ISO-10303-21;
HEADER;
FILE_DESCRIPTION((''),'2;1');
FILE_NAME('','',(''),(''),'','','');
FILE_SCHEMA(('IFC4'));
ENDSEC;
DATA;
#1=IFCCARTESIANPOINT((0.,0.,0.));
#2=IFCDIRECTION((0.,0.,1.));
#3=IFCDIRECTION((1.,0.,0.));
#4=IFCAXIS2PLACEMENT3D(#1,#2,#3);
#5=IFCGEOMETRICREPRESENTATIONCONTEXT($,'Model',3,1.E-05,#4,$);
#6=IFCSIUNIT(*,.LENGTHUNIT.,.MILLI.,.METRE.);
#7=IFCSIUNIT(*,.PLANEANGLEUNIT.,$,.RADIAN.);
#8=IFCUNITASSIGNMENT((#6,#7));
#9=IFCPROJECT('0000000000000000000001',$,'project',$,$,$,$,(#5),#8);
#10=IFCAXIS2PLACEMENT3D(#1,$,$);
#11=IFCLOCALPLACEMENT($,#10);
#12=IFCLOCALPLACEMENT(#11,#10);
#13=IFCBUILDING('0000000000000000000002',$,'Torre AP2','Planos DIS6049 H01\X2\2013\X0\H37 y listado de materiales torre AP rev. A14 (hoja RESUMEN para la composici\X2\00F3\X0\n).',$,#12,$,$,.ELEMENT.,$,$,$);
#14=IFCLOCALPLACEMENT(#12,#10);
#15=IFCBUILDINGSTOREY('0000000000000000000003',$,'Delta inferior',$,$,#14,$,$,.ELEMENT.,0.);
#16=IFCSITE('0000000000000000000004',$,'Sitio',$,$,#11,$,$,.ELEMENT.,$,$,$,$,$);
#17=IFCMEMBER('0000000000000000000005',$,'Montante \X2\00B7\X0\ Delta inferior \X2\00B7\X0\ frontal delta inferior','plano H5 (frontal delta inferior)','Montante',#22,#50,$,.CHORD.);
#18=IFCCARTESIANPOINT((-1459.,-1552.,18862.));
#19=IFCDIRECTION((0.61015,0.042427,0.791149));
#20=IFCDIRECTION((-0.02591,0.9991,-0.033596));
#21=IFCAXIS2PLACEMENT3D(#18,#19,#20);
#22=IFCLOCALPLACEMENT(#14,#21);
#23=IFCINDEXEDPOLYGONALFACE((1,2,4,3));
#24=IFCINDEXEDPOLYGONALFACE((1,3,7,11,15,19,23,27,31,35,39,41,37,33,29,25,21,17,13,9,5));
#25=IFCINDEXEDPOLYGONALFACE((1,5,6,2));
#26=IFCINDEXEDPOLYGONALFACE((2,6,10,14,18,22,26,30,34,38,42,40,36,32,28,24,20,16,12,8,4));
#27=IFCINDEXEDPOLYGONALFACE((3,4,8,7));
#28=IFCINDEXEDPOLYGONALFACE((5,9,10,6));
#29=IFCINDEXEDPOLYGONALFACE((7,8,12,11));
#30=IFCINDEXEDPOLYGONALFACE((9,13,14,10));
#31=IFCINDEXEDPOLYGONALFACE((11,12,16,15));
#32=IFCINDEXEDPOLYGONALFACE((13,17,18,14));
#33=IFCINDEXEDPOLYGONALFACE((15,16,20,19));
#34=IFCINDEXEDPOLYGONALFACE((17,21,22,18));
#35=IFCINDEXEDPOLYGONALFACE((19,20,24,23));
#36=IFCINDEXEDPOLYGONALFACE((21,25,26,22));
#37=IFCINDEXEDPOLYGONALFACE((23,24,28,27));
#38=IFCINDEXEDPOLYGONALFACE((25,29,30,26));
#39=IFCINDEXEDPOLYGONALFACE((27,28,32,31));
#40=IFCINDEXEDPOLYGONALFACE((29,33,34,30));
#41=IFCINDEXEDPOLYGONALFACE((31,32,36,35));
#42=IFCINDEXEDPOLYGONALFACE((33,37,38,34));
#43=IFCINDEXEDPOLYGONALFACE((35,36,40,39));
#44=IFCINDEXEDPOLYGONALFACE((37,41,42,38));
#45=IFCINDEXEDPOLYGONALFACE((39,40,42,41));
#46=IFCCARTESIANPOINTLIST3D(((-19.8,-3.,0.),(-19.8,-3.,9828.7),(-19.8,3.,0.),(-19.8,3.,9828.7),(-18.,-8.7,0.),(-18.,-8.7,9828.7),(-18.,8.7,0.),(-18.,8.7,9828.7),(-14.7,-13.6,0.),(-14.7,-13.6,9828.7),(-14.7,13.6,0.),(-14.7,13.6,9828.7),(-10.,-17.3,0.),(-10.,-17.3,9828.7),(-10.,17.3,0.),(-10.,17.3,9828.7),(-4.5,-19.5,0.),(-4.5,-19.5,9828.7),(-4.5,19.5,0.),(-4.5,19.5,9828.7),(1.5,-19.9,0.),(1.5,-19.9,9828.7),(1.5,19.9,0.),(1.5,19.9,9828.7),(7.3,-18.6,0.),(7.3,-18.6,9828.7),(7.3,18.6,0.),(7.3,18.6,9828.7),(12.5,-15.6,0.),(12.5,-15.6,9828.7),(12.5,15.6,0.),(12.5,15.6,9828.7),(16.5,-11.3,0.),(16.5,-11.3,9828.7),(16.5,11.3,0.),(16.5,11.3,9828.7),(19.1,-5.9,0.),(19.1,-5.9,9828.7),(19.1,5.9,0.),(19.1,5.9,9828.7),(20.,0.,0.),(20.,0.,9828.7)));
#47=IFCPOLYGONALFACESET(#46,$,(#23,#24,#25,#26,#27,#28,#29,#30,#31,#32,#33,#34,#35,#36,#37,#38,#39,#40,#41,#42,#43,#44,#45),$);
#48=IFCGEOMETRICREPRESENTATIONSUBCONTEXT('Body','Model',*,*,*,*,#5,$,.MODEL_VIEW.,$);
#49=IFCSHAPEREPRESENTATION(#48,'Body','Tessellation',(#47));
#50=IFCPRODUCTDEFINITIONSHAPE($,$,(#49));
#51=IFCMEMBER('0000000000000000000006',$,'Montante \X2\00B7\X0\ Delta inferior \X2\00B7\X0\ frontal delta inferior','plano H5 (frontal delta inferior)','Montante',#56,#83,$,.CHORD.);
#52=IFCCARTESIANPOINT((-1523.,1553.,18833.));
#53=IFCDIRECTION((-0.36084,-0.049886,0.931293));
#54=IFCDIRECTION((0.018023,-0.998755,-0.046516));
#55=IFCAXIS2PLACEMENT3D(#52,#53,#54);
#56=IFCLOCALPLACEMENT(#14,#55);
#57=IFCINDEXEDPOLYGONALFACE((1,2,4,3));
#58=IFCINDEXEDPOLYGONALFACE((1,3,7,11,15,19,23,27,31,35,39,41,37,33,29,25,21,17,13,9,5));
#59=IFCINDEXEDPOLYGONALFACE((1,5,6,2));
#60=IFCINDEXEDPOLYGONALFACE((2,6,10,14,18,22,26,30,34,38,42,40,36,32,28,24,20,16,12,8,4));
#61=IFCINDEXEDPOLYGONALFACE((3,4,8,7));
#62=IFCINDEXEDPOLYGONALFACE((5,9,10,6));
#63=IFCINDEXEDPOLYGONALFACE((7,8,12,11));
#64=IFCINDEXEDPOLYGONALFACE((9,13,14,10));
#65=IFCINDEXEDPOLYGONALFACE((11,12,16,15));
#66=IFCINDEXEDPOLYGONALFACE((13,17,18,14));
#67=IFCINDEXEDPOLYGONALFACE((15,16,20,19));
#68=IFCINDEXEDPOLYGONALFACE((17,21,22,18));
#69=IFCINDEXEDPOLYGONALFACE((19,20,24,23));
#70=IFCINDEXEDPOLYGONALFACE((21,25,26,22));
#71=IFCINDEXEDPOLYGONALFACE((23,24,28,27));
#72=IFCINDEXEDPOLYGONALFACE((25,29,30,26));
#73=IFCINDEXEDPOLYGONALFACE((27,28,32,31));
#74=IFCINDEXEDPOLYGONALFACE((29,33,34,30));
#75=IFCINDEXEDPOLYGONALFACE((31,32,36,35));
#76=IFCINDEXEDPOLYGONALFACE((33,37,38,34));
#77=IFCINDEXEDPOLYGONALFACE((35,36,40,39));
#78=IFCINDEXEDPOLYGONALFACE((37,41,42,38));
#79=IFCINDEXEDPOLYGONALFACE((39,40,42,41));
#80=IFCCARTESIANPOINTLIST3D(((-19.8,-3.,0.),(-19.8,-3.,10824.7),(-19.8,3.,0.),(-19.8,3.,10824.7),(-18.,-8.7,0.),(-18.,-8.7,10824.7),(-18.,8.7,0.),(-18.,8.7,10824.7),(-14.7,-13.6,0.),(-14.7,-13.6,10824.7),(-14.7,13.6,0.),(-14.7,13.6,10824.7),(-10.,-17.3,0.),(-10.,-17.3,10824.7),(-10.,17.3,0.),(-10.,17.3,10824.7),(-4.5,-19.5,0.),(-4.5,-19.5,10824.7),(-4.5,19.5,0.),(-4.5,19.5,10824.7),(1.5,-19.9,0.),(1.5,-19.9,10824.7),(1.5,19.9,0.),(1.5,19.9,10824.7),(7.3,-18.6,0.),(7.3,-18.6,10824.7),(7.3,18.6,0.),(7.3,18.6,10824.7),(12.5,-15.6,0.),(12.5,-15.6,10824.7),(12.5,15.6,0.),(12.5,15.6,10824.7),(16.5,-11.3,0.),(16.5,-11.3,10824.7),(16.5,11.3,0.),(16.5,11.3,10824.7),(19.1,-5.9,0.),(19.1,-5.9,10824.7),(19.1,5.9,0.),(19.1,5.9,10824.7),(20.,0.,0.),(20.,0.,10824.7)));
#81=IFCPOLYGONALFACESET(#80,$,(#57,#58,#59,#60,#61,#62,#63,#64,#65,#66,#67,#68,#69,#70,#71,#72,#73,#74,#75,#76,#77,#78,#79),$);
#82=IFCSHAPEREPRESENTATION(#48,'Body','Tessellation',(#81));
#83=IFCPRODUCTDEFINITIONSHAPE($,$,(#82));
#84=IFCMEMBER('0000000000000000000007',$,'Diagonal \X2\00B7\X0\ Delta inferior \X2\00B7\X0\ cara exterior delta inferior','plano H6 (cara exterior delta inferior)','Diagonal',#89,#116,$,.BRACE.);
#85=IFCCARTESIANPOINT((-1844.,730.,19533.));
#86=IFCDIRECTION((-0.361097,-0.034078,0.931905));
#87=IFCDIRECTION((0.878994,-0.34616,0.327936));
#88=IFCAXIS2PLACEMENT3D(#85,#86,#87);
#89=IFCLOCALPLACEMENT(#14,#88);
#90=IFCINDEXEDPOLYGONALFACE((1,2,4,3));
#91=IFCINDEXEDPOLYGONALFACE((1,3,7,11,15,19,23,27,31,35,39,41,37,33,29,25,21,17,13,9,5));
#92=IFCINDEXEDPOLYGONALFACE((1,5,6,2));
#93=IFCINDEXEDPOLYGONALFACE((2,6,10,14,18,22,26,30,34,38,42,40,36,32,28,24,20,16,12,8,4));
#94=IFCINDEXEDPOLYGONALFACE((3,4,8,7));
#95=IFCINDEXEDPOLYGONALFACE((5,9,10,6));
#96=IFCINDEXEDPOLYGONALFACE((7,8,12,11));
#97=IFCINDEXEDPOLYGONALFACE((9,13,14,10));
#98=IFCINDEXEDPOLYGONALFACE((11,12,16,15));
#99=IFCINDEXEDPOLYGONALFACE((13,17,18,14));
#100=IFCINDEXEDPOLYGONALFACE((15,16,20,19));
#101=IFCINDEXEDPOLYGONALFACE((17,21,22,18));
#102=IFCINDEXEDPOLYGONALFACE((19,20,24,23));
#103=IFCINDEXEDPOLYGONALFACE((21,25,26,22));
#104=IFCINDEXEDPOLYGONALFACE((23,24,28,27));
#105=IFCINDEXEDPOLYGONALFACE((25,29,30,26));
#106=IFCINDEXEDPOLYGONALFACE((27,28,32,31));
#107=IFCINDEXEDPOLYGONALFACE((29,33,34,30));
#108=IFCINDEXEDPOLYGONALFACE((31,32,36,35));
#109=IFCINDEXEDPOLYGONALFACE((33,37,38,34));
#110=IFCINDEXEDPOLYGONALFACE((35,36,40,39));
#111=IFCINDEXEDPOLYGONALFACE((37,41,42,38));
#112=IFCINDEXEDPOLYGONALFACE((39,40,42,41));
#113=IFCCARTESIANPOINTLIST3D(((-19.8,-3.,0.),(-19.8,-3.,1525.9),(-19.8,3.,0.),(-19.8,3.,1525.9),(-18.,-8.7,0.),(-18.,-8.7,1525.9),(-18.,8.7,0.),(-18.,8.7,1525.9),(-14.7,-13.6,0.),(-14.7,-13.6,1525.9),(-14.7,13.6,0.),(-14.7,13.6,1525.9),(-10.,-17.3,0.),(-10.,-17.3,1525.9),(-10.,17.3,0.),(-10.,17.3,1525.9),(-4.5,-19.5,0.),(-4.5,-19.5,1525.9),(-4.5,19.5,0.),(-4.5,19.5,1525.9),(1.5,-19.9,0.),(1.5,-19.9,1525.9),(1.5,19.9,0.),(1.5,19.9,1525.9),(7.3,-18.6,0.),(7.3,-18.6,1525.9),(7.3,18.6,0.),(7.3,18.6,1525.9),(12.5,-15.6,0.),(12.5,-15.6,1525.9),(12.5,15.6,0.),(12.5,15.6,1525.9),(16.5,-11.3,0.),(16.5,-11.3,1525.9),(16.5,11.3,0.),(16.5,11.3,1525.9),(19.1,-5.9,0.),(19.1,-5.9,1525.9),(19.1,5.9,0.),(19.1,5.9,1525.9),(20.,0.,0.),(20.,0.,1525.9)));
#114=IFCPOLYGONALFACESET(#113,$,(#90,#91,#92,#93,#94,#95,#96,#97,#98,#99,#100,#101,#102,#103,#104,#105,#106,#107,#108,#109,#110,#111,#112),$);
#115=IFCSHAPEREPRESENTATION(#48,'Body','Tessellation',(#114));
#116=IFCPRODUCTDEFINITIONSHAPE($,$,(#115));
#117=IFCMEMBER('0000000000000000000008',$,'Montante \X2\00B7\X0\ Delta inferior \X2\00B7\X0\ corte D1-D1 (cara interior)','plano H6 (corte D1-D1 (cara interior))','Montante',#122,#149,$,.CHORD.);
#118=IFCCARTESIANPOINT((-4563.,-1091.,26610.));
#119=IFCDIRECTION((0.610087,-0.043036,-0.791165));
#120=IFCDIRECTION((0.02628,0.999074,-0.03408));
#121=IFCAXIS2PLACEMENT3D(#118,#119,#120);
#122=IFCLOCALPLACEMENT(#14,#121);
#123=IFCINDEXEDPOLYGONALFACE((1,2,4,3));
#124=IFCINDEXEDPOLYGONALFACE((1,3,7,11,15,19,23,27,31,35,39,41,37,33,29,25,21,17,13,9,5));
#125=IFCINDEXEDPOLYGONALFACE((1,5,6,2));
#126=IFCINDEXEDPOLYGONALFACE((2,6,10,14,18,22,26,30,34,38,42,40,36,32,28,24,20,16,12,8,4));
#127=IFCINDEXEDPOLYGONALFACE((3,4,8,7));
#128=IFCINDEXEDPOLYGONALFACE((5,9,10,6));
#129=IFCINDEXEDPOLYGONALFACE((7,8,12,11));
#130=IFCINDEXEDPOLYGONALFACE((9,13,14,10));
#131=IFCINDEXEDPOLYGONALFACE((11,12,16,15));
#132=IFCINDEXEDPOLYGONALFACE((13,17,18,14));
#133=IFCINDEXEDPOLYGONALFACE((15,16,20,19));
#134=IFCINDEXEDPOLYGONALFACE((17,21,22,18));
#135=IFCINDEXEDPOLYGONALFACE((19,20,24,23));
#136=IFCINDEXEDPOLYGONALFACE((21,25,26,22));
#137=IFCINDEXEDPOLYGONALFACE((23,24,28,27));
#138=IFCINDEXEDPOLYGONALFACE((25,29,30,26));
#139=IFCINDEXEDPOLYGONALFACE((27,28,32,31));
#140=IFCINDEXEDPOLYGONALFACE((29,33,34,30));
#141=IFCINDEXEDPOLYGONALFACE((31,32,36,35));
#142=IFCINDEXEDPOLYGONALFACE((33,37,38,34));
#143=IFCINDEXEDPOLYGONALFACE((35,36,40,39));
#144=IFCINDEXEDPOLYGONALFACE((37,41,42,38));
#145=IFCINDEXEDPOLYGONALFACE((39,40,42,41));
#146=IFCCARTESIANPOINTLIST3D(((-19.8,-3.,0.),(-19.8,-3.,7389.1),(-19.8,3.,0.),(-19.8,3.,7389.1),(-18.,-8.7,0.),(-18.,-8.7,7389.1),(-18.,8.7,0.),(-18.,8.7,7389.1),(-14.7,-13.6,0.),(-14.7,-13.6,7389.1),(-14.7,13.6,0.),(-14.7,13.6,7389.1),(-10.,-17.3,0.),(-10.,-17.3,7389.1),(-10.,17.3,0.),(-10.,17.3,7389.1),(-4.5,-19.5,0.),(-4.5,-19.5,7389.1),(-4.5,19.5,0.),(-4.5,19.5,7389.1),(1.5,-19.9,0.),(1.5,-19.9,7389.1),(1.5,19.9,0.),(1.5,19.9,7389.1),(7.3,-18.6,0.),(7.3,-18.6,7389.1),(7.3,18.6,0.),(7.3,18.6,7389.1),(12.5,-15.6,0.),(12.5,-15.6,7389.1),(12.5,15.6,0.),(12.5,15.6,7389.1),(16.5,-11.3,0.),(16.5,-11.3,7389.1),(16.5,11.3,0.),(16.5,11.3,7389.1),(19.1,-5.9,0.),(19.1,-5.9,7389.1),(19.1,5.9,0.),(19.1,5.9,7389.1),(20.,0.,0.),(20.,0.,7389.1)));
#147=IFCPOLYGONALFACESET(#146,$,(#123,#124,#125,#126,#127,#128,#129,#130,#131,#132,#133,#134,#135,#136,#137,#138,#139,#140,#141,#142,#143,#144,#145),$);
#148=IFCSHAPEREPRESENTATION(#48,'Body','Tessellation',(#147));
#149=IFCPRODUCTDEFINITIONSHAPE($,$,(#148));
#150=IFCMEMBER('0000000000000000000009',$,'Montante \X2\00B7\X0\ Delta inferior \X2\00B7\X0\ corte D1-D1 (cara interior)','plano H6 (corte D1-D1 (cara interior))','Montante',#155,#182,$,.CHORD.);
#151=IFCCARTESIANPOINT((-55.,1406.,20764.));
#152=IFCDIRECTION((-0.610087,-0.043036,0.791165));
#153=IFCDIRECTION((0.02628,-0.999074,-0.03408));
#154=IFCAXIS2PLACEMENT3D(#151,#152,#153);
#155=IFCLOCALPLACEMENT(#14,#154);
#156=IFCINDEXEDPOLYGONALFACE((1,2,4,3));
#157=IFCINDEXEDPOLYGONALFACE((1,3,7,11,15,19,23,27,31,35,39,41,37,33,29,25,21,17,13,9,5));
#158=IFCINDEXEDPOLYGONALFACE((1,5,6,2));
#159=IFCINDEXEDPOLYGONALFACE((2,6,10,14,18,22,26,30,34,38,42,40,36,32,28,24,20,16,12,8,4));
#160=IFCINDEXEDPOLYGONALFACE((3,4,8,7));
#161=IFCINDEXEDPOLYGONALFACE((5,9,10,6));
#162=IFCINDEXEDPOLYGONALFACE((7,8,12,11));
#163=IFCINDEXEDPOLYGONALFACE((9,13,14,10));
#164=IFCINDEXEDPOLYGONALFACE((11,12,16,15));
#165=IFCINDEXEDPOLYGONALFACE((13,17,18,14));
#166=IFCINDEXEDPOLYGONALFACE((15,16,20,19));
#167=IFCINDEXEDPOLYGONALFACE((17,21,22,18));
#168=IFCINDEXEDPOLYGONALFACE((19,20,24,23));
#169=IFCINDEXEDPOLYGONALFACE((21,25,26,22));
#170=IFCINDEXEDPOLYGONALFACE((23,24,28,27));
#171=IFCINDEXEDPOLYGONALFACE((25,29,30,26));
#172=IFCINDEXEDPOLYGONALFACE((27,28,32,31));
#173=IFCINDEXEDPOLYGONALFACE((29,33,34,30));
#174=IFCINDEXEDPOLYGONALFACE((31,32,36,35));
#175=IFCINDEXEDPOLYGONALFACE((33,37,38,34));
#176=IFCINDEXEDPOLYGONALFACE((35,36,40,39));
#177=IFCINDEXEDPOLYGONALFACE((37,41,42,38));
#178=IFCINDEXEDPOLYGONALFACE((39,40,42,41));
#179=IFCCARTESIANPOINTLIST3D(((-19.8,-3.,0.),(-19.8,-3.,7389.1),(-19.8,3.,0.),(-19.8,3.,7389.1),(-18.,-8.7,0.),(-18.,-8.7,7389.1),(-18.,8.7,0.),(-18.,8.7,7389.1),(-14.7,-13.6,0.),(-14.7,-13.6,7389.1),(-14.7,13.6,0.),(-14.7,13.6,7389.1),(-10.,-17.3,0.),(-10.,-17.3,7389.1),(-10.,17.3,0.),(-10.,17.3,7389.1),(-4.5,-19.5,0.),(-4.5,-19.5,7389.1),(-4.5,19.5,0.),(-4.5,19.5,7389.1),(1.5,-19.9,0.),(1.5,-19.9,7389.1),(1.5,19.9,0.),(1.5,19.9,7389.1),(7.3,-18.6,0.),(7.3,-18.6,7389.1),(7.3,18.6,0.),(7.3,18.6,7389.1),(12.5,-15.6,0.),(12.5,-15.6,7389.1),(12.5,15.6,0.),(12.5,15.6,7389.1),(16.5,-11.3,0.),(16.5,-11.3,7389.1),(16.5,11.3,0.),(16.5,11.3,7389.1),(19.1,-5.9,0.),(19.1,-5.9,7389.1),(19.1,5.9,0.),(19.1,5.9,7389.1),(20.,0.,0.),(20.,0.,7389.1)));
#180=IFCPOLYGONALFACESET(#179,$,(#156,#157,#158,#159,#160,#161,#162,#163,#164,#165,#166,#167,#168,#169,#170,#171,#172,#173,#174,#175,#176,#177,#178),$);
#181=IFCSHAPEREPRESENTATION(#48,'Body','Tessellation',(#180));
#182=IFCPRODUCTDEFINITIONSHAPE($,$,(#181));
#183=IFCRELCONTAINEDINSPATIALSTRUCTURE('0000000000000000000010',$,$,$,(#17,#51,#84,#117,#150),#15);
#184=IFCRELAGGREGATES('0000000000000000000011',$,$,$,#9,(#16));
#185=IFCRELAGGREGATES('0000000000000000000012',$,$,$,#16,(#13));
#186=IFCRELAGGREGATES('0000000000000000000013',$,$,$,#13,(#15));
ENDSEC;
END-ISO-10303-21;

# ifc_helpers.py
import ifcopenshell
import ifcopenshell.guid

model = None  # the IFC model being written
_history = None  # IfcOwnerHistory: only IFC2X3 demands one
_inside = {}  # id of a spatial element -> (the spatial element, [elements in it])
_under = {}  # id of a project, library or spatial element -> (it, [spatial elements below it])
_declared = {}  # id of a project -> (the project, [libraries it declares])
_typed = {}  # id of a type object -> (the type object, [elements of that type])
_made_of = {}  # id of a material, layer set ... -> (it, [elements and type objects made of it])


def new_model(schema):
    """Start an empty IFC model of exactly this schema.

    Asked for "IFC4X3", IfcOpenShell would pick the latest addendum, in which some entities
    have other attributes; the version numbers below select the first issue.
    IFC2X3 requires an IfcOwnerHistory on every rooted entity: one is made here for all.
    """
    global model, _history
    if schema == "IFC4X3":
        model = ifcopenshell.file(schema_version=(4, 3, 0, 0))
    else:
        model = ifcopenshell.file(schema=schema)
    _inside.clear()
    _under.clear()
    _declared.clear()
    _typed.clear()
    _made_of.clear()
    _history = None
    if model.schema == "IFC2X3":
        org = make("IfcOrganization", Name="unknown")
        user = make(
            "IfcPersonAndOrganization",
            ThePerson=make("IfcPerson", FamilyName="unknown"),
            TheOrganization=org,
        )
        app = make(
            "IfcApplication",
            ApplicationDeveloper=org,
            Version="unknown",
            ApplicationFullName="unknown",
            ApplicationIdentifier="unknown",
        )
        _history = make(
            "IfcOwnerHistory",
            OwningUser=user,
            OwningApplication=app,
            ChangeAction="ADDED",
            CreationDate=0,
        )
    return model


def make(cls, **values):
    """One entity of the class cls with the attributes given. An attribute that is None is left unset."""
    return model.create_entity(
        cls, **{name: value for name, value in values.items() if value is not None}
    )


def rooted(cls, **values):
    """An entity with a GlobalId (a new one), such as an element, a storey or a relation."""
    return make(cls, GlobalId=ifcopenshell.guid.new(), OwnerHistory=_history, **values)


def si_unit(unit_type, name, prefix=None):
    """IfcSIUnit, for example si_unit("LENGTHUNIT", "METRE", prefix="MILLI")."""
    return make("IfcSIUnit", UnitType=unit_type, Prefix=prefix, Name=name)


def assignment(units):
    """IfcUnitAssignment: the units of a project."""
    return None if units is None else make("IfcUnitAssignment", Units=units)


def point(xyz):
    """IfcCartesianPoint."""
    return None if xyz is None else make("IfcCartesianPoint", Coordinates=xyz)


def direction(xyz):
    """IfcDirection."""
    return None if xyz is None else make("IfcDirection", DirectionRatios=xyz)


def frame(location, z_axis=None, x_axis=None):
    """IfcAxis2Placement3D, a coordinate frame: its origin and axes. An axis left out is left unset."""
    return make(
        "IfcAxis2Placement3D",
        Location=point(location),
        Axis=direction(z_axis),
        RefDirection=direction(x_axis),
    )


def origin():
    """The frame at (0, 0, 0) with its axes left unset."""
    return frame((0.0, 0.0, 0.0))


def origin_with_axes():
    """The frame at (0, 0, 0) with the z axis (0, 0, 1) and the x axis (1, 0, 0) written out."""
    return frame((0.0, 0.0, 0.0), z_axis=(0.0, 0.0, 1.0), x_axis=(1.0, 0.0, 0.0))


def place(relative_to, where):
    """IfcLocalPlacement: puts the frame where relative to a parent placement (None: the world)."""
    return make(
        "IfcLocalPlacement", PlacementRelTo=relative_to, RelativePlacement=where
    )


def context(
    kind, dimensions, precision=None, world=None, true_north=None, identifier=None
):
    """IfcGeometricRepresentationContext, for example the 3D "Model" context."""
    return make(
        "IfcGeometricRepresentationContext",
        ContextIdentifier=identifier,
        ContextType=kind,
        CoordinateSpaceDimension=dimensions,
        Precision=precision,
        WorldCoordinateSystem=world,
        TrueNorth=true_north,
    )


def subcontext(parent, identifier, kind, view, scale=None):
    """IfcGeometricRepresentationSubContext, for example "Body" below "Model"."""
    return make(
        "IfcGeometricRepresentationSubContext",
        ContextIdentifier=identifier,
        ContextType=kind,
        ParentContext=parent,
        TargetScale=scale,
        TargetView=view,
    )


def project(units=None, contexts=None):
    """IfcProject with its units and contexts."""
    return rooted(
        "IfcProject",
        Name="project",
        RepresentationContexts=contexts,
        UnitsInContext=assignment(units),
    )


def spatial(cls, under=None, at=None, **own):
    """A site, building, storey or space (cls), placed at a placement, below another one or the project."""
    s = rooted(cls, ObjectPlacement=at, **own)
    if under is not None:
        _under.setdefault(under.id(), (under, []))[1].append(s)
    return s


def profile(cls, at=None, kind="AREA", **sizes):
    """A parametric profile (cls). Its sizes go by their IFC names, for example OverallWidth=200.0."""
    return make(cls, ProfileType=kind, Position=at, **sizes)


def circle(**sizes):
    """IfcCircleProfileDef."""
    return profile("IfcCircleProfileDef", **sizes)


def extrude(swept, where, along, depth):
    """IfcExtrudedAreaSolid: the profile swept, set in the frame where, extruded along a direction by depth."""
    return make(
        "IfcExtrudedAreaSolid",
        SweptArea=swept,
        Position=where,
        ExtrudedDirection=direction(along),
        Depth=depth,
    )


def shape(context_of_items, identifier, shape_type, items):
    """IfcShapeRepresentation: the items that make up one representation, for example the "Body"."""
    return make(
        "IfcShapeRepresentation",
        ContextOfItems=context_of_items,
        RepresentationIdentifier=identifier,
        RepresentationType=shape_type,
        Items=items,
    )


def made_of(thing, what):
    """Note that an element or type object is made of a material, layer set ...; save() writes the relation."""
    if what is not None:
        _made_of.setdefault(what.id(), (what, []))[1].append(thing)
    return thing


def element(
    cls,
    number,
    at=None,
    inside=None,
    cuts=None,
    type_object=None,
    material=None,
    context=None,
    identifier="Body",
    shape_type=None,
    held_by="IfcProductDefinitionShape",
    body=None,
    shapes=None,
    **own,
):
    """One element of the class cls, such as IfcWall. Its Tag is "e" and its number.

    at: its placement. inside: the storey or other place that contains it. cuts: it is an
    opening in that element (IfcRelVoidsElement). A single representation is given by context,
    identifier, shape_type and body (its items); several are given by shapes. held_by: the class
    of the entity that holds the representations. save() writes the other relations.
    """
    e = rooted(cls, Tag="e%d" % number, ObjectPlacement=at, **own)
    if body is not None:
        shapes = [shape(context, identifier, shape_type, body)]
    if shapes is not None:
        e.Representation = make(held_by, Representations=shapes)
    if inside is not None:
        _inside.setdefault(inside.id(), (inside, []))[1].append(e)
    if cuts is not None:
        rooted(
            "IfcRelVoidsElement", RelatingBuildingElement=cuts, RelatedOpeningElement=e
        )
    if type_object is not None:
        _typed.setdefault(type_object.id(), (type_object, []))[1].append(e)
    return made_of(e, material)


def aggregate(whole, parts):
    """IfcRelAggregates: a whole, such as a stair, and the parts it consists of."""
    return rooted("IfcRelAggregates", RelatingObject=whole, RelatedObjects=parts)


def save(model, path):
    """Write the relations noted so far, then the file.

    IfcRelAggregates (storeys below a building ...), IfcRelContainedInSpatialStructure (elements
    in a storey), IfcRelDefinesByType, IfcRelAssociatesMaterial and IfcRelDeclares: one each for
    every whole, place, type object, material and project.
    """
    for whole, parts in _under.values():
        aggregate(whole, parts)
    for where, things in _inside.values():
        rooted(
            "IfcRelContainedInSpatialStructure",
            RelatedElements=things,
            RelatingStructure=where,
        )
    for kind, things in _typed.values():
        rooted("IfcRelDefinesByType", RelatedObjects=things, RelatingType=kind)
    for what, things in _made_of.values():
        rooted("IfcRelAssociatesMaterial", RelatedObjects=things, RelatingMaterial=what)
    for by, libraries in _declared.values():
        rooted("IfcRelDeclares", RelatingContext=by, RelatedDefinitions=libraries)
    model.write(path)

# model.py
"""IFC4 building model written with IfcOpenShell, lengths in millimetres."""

from ifc_helpers import new_model, si_unit, frame, origin, origin_with_axes, place, context, subcontext, project, spatial, circle, extrude, element, save


model = new_model("IFC4")

# Units and contexts
model_context = context("Model", 3, precision=1e-05, world=origin_with_axes())
body_context = subcontext(model_context, "Body", "Model", "MODEL_VIEW")
ifc_project = project(units=[si_unit("LENGTHUNIT", "METRE", prefix="MILLI"), si_unit("PLANEANGLEUNIT", "RADIAN")], contexts=[model_context])

# Site, building, storey
site_placement = place(None, origin())
site = spatial("IfcSite", under=ifc_project, at=site_placement, Name="Sitio", CompositionType="ELEMENT")
building_placement = place(site_placement, origin())
building = spatial("IfcBuilding", under=site, at=building_placement, Name="Torre AP2", Description="Planos DIS6049 H01–H37 y listado de materiales torre AP rev. A14 (hoja RESUMEN para la composición).", CompositionType="ELEMENT")
storey_placement = place(building_placement, origin())
storey = spatial("IfcBuildingStorey", under=building, at=storey_placement, Name="Delta inferior", CompositionType="ELEMENT", Elevation=0.0)

# Members
for number, where, z_axis, x_axis, name in (
    (1, (-1459.0, -1552.0, 18862.0), (0.61015, 0.042427, 0.791149), (-0.02591, 0.9991, -0.033596), "Montante · Delta inferior · frontal delta inferior"),
):
    element("IfcMember", number, at=place(storey_placement, frame(where, z_axis=z_axis, x_axis=x_axis)), inside=storey, Name=name, Description="plano H5 (frontal delta inferior)", ObjectType="Montante", PredefinedType="CHORD", context=body_context, shape_type="SweptSolid", body=[
        extrude(circle(Radius=20.0), None, (0.0, 0.0, 1.0), 9828.7),
    ])
for number, where, z_axis, x_axis, name in (
    (2, (-1523.0, 1553.0, 18833.0), (-0.36084, -0.049886, 0.931293), (0.018023, -0.998755, -0.046516), "Montante · Delta inferior · frontal delta inferior"),
):
    element("IfcMember", number, at=place(storey_placement, frame(where, z_axis=z_axis, x_axis=x_axis)), inside=storey, Name=name, Description="plano H5 (frontal delta inferior)", ObjectType="Montante", PredefinedType="CHORD", context=body_context, shape_type="SweptSolid", body=[
        extrude(circle(Radius=20.0), None, (0.0, 0.0, 1.0), 10824.7),
    ])
member_1_placement = place(storey_placement, frame((-1844.0, 730.0, 19533.0), z_axis=(-0.361097, -0.034078, 0.931905), x_axis=(0.878994, -0.34616, 0.327936)))
element("IfcMember", 3, at=member_1_placement, inside=storey, Name="Diagonal · Delta inferior · cara exterior delta inferior", Description="plano H6 (cara exterior delta inferior)", ObjectType="Diagonal", PredefinedType="BRACE", context=body_context, shape_type="SweptSolid", body=[
    extrude(circle(Radius=20.0), None, (0.0, 0.0, 1.0), 1525.9),
])
member_2_placement = place(storey_placement, frame((-4563.0, -1091.0, 26610.0), z_axis=(0.610087, -0.043036, -0.791165), x_axis=(0.02628, 0.999074, -0.03408)))
element("IfcMember", 4, at=member_2_placement, inside=storey, Name="Montante · Delta inferior · corte D1-D1 (cara interior)", Description="plano H6 (corte D1-D1 (cara interior))", ObjectType="Montante", PredefinedType="CHORD", context=body_context, shape_type="SweptSolid", body=[
    extrude(circle(Radius=20.0), None, (0.0, 0.0, 1.0), 7389.1),
])
for number, where, z_axis, x_axis, name in (
    (5, (-55.0, 1406.0, 20764.0), (-0.610087, -0.043036, 0.791165), (0.02628, -0.999074, -0.03408), "Montante · Delta inferior · corte D1-D1 (cara interior)"),
):
    element("IfcMember", number, at=place(storey_placement, frame(where, z_axis=z_axis, x_axis=x_axis)), inside=storey, Name=name, Description="plano H6 (corte D1-D1 (cara interior))", ObjectType="Montante", PredefinedType="CHORD", context=body_context, shape_type="SweptSolid", body=[
        extrude(circle(Radius=20.0), None, (0.0, 0.0, 1.0), 7389.1),
    ])

save(model, "model.ifc")
